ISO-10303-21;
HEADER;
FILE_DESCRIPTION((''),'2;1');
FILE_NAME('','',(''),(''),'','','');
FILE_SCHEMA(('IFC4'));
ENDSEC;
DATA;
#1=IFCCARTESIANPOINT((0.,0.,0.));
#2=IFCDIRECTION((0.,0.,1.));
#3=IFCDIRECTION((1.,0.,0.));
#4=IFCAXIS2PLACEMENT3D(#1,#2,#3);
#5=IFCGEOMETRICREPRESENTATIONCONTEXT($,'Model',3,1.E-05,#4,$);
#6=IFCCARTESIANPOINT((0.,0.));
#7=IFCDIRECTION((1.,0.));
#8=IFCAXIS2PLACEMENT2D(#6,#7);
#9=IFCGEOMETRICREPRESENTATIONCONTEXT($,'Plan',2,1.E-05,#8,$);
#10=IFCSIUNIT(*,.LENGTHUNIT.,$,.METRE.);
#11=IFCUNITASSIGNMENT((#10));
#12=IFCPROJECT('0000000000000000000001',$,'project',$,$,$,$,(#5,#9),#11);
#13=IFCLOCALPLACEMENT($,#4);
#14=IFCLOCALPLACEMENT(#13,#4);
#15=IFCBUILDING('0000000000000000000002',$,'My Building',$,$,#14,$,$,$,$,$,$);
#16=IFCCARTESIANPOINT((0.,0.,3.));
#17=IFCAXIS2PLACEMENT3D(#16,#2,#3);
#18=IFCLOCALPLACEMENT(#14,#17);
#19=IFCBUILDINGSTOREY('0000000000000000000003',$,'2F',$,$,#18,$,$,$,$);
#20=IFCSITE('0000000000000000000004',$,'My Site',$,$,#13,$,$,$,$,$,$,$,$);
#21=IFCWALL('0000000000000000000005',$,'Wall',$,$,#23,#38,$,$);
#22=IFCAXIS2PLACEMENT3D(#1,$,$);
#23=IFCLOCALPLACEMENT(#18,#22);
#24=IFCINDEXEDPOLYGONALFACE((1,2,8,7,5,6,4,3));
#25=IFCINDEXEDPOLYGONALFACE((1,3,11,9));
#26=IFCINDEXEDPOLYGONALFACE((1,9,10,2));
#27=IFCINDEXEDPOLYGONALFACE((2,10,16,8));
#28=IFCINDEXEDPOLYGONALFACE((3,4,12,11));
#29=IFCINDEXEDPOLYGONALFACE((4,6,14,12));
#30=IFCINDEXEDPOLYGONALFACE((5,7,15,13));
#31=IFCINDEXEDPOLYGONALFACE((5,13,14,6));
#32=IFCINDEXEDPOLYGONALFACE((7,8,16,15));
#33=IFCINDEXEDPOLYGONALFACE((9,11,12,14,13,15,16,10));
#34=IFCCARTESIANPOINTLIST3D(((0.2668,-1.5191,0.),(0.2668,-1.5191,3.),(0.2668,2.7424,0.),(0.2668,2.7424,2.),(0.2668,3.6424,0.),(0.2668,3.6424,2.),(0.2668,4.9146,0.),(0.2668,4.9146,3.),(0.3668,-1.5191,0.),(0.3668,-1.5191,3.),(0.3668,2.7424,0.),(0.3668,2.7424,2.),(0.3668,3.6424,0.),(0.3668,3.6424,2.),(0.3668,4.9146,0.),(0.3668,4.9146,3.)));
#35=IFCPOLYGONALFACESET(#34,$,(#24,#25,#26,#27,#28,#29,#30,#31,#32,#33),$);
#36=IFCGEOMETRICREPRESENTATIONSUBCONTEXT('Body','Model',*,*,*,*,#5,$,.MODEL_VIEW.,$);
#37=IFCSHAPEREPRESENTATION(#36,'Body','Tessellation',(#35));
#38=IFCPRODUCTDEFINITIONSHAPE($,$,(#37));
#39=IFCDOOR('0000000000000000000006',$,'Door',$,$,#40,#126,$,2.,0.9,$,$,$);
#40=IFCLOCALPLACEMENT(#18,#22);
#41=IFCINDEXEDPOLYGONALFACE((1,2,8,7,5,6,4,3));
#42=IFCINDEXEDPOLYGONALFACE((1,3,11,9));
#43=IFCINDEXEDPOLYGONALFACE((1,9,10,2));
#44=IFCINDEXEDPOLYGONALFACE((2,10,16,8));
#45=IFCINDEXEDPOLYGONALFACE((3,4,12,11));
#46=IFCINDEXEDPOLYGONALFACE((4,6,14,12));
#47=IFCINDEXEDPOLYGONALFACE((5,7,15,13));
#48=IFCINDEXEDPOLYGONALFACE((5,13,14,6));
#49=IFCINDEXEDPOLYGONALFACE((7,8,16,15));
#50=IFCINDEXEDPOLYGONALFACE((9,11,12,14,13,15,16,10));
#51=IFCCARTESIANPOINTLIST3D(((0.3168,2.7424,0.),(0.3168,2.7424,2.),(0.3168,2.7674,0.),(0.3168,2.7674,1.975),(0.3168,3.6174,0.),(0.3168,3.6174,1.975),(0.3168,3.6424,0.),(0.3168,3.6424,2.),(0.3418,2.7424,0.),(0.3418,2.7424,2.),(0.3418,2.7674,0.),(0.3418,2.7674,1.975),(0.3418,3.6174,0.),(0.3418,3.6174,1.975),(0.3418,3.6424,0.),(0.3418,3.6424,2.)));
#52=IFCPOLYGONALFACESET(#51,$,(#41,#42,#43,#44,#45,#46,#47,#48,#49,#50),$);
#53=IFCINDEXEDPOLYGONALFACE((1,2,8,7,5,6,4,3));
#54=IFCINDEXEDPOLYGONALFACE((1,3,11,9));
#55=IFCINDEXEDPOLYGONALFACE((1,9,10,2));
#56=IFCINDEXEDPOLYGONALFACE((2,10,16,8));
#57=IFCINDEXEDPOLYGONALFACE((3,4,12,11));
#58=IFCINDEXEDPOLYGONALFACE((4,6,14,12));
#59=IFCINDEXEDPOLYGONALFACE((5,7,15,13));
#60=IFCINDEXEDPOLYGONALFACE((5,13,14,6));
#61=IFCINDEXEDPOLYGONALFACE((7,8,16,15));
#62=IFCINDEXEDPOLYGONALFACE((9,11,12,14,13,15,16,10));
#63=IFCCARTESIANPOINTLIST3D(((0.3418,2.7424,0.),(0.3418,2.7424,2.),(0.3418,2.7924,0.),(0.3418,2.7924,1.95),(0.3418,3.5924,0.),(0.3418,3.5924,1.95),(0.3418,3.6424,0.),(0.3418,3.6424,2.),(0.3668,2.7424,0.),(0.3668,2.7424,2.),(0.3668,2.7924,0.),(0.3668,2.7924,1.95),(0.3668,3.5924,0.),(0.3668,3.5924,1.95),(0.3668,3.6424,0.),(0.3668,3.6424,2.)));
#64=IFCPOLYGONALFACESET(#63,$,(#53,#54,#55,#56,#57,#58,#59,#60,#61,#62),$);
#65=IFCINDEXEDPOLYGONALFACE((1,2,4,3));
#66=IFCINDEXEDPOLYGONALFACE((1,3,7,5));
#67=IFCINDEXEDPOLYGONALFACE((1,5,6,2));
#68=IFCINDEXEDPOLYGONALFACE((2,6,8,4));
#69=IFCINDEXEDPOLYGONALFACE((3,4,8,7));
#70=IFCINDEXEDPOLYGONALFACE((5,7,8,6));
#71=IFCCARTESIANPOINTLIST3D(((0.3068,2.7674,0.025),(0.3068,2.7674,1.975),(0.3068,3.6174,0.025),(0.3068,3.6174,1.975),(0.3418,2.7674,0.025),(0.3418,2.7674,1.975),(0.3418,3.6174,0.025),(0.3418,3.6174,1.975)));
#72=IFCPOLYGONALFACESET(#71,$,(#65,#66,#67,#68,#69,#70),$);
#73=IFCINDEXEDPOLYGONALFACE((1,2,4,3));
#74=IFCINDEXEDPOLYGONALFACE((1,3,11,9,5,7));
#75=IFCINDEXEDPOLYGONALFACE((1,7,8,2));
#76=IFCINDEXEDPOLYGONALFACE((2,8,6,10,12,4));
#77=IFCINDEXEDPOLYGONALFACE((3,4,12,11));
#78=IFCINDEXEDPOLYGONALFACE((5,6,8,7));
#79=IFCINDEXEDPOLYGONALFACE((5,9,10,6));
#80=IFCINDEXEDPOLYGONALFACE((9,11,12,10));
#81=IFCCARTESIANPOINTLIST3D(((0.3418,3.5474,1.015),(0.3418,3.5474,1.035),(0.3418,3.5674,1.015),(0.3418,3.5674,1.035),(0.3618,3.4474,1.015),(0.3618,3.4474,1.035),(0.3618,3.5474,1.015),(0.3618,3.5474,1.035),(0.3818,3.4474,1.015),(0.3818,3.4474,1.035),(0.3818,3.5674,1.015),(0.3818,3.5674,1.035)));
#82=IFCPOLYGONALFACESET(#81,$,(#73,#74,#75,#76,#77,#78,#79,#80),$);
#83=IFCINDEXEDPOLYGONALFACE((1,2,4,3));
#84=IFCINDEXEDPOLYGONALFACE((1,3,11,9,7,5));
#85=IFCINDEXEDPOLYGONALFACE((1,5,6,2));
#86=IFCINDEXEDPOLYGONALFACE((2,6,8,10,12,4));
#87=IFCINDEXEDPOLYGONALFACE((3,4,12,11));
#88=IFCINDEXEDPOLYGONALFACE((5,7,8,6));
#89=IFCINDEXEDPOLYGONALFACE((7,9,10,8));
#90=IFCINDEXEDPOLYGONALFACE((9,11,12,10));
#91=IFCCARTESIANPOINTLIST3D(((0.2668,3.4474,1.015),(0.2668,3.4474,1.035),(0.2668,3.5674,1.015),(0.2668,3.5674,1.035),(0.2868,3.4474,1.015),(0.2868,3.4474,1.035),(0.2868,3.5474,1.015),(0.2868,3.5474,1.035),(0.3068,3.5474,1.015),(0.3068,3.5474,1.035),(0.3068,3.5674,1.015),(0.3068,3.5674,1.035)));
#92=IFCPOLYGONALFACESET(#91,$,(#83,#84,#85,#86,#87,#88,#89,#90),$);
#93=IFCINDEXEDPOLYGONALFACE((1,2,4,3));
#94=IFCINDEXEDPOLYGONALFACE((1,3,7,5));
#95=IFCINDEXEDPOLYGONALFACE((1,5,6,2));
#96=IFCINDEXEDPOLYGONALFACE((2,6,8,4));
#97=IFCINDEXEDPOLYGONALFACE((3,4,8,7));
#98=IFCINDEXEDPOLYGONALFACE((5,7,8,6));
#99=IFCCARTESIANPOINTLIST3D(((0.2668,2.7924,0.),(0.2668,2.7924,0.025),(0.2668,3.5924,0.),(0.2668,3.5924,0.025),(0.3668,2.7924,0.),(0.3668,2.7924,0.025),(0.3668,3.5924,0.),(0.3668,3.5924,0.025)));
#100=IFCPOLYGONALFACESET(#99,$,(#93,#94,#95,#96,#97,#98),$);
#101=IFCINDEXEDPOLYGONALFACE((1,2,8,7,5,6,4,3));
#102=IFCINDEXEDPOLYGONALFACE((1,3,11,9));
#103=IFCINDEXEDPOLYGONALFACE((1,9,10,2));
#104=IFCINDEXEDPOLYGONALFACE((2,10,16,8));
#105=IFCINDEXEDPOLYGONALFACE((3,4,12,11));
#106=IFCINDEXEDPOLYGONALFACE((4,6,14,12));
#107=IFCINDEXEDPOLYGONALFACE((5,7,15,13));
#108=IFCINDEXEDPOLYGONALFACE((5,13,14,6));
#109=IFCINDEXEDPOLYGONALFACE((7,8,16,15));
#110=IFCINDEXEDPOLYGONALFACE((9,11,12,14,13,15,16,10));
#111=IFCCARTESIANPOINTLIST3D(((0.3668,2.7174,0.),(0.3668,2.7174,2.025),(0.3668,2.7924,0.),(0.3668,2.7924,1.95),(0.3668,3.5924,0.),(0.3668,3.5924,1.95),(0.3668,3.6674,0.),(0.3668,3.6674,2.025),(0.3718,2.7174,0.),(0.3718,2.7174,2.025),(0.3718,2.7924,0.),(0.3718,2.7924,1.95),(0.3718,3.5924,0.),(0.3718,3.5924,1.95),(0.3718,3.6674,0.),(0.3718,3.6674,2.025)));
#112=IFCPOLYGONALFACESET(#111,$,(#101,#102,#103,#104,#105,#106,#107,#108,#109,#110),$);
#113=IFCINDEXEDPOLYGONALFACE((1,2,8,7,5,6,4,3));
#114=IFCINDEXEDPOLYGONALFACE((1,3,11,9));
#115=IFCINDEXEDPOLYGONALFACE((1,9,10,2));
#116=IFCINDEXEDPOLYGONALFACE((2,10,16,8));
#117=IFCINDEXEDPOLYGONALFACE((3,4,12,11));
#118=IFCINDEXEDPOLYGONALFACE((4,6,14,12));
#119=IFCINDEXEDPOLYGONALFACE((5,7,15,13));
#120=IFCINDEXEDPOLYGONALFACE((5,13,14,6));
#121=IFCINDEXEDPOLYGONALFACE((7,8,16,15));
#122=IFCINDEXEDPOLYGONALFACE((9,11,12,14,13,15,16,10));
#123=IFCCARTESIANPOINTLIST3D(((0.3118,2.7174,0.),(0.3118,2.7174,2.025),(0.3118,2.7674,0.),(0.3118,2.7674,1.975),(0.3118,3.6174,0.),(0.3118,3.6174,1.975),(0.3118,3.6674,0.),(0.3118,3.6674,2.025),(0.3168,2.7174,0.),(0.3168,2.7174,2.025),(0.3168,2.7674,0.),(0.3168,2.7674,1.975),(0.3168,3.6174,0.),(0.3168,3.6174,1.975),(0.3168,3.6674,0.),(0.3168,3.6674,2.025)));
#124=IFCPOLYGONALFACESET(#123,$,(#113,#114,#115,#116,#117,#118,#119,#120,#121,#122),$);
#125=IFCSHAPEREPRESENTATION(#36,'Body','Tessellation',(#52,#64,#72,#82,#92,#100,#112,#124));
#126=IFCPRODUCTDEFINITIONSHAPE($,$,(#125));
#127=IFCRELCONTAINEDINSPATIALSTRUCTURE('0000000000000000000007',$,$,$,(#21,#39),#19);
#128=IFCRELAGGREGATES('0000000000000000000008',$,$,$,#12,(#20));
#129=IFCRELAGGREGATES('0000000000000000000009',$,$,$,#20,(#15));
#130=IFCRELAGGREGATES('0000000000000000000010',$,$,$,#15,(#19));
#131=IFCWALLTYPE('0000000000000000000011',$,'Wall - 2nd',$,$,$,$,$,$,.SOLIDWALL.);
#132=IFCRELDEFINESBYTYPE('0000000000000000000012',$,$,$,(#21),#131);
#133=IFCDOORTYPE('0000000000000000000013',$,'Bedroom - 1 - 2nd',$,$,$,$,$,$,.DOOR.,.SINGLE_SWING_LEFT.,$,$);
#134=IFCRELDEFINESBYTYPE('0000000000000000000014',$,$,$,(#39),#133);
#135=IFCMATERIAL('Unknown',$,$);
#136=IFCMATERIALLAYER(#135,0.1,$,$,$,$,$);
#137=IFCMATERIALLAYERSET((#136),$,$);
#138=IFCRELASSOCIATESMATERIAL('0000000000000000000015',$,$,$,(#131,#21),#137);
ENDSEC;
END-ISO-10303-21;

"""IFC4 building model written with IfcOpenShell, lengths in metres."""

from ifc_helpers import new_model, entity, si_unit, frame, origin_with_axes, origin_2d_with_axis, place, context, subcontext, project, spatial, line, indexed_curve, outline, extrude, shape, source, transform, mapped, material, layer, layer_set, layer_usage, type_object, type_shapes, element, fill, save


model = new_model("IFC4")

# Units and contexts
model_context = context("Model", 3, precision=1e-05, world=origin_with_axes())
plan_context = context("Plan", 2, precision=1e-05, world=origin_2d_with_axis())
body_context_1 = subcontext(model_context, "Body", "Model", "MODEL_VIEW")
body_context_2 = subcontext(plan_context, "Body", "Plan", "PLAN_VIEW")
ifc_project = project(units=[si_unit("LENGTHUNIT", "METRE")], contexts=[model_context, plan_context])

# Site, building, storey
site_placement = place(None, origin_with_axes())
site = spatial("IfcSite", under=ifc_project, at=site_placement, Name="My Site")
building_placement = place(site_placement, origin_with_axes())
building = spatial("IfcBuilding", under=site, at=building_placement, Name="My Building")
storey_placement = place(building_placement, frame((0.0, 0.0, 3.0), z_axis=(0.0, 0.0, 1.0), x_axis=(1.0, 0.0, 0.0)))
storey = spatial("IfcBuildingStorey", under=building, at=storey_placement, Name="2F")

# Shared definitions
ifc_material = material(Name="Unknown")

# Shared definitions
ifc_layer_1 = layer(ifc_material, 0.1)
ifc_layer_set_1 = layer_set([ifc_layer_1])
wall_type = type_object("IfcWallType", Name="Wall - 2nd", PredefinedType="SOLIDWALL", material=ifc_layer_set_1)

# Wall, opening, door
ifc_layer_usage_1 = layer_usage(ifc_layer_set_1, "AXIS2", "POSITIVE", 0.0)
wall_1_placement = place(storey_placement, frame((0.3668, -1.5191, 0.0), z_axis=(0.0, 0.0, 1.0), x_axis=(0.0, 1.0, 0.0)))
wall_1 = element("IfcWall", 1, at=wall_1_placement, inside=storey, type_object=wall_type, material=ifc_layer_usage_1, Name="Wall", context=body_context_1, shape_type="SweptSolid", body=[
    extrude(outline(indexed_curve([(0.0, 0.0), (0.0, 0.1), (6.4337, 0.1), (6.4337, 0.0)], segments=[line(1, 2, 3, 4, 1)])), origin_with_axes(), (0.0, 0.0, 1.0), 3.0),
])
shared_shape_1 = source(origin_with_axes(), body_context_1, "Body", "SweptSolid", [
    extrude(outline(indexed_curve([(0.0, 0.0), (0.9, 0.0), (0.9, 2.0), (0.0, 2.0)], segments=[line(1, 2, 3, 4, 1)])), frame((0.0, -0.6, 0.0), z_axis=(0.0, -1.0, 0.0), x_axis=(1.0, 0.0, 0.0)), (0.0, 0.0, -1.0), 1.2),
])
opening_1_placement = place(wall_1_placement, frame((4.2615, 0.0, 0.0), z_axis=(0.0, 0.0, 1.0), x_axis=(1.0, 0.0, 0.0)))
opening_1 = element("IfcOpeningElement", 2, at=opening_1_placement, cuts=wall_1, PredefinedType="OPENING", context=body_context_1, shape_type="MappedRepresentation", body=[
    mapped(shared_shape_1, transform((0.0, 0.0, 0.0), x_axis=(1.0, 0.0, 0.0), y_axis=(0.0, 1.0, 0.0), z_axis=(0.0, 0.0, 1.0), scale=1.0)),
])
door_type_1 = type_object("IfcDoorType", Name="Bedroom - 1 - 2nd", OperationType="SINGLE_SWING_LEFT", PredefinedType="DOOR")
shared_shape_2 = source(origin_with_axes(), body_context_1, "Body", "SweptSolid", [
    extrude(outline(indexed_curve([(0.0, 0.0), (0.0, 2.0), (0.9, 2.0), (0.9, 0.0), (0.875, 0.0), (0.875, 1.975), (0.025, 1.975), (0.025, 0.0)], segments=[line(1, 2, 3, 4, 5, 6, 7, 8, 1)])), frame((0.0, 0.025, 0.0), z_axis=(0.0, -1.0, 0.0), x_axis=(1.0, 0.0, 0.0)), (0.0, 0.0, -1.0), 0.025),
    extrude(outline(indexed_curve([(0.0, 0.0), (0.0, 2.0), (0.9, 2.0), (0.9, 0.0), (0.85, 0.0), (0.85, 1.95), (0.05, 1.95), (0.05, 0.0)], segments=[line(1, 2, 3, 4, 5, 6, 7, 8, 1)])), frame((0.0, 0.0, 0.0), z_axis=(0.0, -1.0, 0.0), x_axis=(1.0, 0.0, 0.0)), (0.0, 0.0, -1.0), 0.025),
    extrude(outline(indexed_curve([(0.0, 0.0), (0.85, 0.0), (0.85, 0.035), (0.0, 0.035)], segments=[line(1, 2, 3, 4, 1)])), frame((0.025, 0.025, 0.025), z_axis=(0.0, 0.0, 1.0), x_axis=(1.0, 0.0, 0.0)), (0.0, 0.0, 1.0), 1.95),
    extrude(outline(indexed_curve([(0.0, 0.0), (0.0, -0.04), (-0.12, -0.04), (-0.12, -0.02), (-0.02, -0.02), (-0.02, 0.0)], segments=[line(1, 2, 3, 4, 5, 6, 1)])), frame((0.825, 0.025, 1.015), z_axis=(0.0, 0.0, 1.0), x_axis=(1.0, 0.0, 0.0)), (0.0, 0.0, 1.0), 0.02),
    extrude(outline(indexed_curve([(0.0, 0.0), (0.0, 0.04), (-0.12, 0.04), (-0.12, 0.02), (-0.02, 0.02), (-0.02, 0.0)], segments=[line(1, 2, 3, 4, 5, 6, 1)])), frame((0.825, 0.06, 1.015), z_axis=(0.0, 0.0, 1.0), x_axis=(1.0, 0.0, 0.0)), (0.0, 0.0, 1.0), 0.02),
    extrude(outline(indexed_curve([(0.0, 0.0), (0.8, 0.0), (0.8, 0.1), (0.0, 0.1)], segments=[line(1, 2, 3, 4, 1)])), frame((0.05, 0.0, 0.0), z_axis=(0.0, 0.0, 1.0), x_axis=(1.0, 0.0, 0.0)), (0.0, 0.0, 1.0), 0.025),
    extrude(outline(indexed_curve([(0.0, 0.0), (0.0, 2.025), (0.95, 2.025), (0.95, 0.0), (0.875, 0.0), (0.875, 1.95), (0.075, 1.95), (0.075, 0.0)], segments=[line(1, 2, 3, 4, 5, 6, 7, 8, 1)])), frame((-0.025, -0.005, 0.0), z_axis=(0.0, -1.0, 0.0), x_axis=(1.0, 0.0, 0.0)), (0.0, 0.0, -1.0), 0.005),
    extrude(outline(indexed_curve([(0.0, 0.0), (0.0, 2.025), (0.95, 2.025), (0.95, 0.0), (0.9, 0.0), (0.9, 1.975), (0.05, 1.975), (0.05, 0.0)], segments=[line(1, 2, 3, 4, 5, 6, 7, 8, 1)])), frame((-0.025, 0.05, 0.0), z_axis=(0.0, -1.0, 0.0), x_axis=(1.0, 0.0, 0.0)), (0.0, 0.0, -1.0), 0.005),
])
shared_shape_3 = source(origin_with_axes(), body_context_2, "Body", "Curve2D", [
    entity("IfcIndexedPolyCurve", entity("IfcCartesianPointList2D", [[0.0, 0.0], [0.0, 0.05], [0.025, 0.05], [0.025, 0.025], [0.05, 0.025], [0.05, 0.0]]), [entity("IfcLineIndex", [1, 2, 3, 4, 5, 6, 1])]),
    entity("IfcIndexedPolyCurve", entity("IfcCartesianPointList2D", [[0.9, 0.0], [0.9, 0.05], [0.875, 0.05], [0.875, 0.025], [0.85, 0.025], [0.85, 0.0]]), [entity("IfcLineIndex", [1, 2, 3, 4, 5, 6, 1])]),
    entity("IfcTrimmedCurve", entity("IfcEllipse", entity("IfcAxis2Placement2D", entity("IfcCartesianPoint", [0.06, 0.05]), entity("IfcDirection", [1.0, 0.0])), 0.815, 0.85), [entity("IfcCartesianPoint", [0.875, 0.05])], [entity("IfcCartesianPoint", [0.06, 0.9])], True, "CARTESIAN"),
    entity("IfcIndexedPolyCurve", entity("IfcCartesianPointList2D", [[0.025, 0.05], [0.06, 0.05], [0.06, 0.9], [0.025, 0.9]]), [entity("IfcLineIndex", [1, 2, 3, 4, 1])]),
])
type_shapes(door_type_1, [shared_shape_2, shared_shape_3])
door_1_placement = place(opening_1_placement, frame((0.0, 0.0, 0.0), z_axis=(0.0, 0.0, 1.0), x_axis=(1.0, 0.0, 0.0)))
door_1 = element("IfcDoor", 3, at=door_1_placement, inside=storey, type_object=door_type_1, Name="Door", OverallHeight=2.0, OverallWidth=0.9, shapes=[
    shape(body_context_1, "Body", "MappedRepresentation", [mapped(shared_shape_2, transform((0.0, 0.0, 0.0), x_axis=(1.0, 0.0, 0.0), y_axis=(0.0, 1.0, 0.0), z_axis=(0.0, 0.0, 1.0), scale=1.0))]),
    shape(body_context_2, "Body", "MappedRepresentation", [mapped(shared_shape_3, transform((0.0, 0.0, 0.0), x_axis=(1.0, 0.0, 0.0), y_axis=(0.0, 1.0, 0.0), z_axis=(0.0, 0.0, 1.0), scale=1.0))]),
])
fill(opening_1, door_1)

save(model, "model.ifc")
